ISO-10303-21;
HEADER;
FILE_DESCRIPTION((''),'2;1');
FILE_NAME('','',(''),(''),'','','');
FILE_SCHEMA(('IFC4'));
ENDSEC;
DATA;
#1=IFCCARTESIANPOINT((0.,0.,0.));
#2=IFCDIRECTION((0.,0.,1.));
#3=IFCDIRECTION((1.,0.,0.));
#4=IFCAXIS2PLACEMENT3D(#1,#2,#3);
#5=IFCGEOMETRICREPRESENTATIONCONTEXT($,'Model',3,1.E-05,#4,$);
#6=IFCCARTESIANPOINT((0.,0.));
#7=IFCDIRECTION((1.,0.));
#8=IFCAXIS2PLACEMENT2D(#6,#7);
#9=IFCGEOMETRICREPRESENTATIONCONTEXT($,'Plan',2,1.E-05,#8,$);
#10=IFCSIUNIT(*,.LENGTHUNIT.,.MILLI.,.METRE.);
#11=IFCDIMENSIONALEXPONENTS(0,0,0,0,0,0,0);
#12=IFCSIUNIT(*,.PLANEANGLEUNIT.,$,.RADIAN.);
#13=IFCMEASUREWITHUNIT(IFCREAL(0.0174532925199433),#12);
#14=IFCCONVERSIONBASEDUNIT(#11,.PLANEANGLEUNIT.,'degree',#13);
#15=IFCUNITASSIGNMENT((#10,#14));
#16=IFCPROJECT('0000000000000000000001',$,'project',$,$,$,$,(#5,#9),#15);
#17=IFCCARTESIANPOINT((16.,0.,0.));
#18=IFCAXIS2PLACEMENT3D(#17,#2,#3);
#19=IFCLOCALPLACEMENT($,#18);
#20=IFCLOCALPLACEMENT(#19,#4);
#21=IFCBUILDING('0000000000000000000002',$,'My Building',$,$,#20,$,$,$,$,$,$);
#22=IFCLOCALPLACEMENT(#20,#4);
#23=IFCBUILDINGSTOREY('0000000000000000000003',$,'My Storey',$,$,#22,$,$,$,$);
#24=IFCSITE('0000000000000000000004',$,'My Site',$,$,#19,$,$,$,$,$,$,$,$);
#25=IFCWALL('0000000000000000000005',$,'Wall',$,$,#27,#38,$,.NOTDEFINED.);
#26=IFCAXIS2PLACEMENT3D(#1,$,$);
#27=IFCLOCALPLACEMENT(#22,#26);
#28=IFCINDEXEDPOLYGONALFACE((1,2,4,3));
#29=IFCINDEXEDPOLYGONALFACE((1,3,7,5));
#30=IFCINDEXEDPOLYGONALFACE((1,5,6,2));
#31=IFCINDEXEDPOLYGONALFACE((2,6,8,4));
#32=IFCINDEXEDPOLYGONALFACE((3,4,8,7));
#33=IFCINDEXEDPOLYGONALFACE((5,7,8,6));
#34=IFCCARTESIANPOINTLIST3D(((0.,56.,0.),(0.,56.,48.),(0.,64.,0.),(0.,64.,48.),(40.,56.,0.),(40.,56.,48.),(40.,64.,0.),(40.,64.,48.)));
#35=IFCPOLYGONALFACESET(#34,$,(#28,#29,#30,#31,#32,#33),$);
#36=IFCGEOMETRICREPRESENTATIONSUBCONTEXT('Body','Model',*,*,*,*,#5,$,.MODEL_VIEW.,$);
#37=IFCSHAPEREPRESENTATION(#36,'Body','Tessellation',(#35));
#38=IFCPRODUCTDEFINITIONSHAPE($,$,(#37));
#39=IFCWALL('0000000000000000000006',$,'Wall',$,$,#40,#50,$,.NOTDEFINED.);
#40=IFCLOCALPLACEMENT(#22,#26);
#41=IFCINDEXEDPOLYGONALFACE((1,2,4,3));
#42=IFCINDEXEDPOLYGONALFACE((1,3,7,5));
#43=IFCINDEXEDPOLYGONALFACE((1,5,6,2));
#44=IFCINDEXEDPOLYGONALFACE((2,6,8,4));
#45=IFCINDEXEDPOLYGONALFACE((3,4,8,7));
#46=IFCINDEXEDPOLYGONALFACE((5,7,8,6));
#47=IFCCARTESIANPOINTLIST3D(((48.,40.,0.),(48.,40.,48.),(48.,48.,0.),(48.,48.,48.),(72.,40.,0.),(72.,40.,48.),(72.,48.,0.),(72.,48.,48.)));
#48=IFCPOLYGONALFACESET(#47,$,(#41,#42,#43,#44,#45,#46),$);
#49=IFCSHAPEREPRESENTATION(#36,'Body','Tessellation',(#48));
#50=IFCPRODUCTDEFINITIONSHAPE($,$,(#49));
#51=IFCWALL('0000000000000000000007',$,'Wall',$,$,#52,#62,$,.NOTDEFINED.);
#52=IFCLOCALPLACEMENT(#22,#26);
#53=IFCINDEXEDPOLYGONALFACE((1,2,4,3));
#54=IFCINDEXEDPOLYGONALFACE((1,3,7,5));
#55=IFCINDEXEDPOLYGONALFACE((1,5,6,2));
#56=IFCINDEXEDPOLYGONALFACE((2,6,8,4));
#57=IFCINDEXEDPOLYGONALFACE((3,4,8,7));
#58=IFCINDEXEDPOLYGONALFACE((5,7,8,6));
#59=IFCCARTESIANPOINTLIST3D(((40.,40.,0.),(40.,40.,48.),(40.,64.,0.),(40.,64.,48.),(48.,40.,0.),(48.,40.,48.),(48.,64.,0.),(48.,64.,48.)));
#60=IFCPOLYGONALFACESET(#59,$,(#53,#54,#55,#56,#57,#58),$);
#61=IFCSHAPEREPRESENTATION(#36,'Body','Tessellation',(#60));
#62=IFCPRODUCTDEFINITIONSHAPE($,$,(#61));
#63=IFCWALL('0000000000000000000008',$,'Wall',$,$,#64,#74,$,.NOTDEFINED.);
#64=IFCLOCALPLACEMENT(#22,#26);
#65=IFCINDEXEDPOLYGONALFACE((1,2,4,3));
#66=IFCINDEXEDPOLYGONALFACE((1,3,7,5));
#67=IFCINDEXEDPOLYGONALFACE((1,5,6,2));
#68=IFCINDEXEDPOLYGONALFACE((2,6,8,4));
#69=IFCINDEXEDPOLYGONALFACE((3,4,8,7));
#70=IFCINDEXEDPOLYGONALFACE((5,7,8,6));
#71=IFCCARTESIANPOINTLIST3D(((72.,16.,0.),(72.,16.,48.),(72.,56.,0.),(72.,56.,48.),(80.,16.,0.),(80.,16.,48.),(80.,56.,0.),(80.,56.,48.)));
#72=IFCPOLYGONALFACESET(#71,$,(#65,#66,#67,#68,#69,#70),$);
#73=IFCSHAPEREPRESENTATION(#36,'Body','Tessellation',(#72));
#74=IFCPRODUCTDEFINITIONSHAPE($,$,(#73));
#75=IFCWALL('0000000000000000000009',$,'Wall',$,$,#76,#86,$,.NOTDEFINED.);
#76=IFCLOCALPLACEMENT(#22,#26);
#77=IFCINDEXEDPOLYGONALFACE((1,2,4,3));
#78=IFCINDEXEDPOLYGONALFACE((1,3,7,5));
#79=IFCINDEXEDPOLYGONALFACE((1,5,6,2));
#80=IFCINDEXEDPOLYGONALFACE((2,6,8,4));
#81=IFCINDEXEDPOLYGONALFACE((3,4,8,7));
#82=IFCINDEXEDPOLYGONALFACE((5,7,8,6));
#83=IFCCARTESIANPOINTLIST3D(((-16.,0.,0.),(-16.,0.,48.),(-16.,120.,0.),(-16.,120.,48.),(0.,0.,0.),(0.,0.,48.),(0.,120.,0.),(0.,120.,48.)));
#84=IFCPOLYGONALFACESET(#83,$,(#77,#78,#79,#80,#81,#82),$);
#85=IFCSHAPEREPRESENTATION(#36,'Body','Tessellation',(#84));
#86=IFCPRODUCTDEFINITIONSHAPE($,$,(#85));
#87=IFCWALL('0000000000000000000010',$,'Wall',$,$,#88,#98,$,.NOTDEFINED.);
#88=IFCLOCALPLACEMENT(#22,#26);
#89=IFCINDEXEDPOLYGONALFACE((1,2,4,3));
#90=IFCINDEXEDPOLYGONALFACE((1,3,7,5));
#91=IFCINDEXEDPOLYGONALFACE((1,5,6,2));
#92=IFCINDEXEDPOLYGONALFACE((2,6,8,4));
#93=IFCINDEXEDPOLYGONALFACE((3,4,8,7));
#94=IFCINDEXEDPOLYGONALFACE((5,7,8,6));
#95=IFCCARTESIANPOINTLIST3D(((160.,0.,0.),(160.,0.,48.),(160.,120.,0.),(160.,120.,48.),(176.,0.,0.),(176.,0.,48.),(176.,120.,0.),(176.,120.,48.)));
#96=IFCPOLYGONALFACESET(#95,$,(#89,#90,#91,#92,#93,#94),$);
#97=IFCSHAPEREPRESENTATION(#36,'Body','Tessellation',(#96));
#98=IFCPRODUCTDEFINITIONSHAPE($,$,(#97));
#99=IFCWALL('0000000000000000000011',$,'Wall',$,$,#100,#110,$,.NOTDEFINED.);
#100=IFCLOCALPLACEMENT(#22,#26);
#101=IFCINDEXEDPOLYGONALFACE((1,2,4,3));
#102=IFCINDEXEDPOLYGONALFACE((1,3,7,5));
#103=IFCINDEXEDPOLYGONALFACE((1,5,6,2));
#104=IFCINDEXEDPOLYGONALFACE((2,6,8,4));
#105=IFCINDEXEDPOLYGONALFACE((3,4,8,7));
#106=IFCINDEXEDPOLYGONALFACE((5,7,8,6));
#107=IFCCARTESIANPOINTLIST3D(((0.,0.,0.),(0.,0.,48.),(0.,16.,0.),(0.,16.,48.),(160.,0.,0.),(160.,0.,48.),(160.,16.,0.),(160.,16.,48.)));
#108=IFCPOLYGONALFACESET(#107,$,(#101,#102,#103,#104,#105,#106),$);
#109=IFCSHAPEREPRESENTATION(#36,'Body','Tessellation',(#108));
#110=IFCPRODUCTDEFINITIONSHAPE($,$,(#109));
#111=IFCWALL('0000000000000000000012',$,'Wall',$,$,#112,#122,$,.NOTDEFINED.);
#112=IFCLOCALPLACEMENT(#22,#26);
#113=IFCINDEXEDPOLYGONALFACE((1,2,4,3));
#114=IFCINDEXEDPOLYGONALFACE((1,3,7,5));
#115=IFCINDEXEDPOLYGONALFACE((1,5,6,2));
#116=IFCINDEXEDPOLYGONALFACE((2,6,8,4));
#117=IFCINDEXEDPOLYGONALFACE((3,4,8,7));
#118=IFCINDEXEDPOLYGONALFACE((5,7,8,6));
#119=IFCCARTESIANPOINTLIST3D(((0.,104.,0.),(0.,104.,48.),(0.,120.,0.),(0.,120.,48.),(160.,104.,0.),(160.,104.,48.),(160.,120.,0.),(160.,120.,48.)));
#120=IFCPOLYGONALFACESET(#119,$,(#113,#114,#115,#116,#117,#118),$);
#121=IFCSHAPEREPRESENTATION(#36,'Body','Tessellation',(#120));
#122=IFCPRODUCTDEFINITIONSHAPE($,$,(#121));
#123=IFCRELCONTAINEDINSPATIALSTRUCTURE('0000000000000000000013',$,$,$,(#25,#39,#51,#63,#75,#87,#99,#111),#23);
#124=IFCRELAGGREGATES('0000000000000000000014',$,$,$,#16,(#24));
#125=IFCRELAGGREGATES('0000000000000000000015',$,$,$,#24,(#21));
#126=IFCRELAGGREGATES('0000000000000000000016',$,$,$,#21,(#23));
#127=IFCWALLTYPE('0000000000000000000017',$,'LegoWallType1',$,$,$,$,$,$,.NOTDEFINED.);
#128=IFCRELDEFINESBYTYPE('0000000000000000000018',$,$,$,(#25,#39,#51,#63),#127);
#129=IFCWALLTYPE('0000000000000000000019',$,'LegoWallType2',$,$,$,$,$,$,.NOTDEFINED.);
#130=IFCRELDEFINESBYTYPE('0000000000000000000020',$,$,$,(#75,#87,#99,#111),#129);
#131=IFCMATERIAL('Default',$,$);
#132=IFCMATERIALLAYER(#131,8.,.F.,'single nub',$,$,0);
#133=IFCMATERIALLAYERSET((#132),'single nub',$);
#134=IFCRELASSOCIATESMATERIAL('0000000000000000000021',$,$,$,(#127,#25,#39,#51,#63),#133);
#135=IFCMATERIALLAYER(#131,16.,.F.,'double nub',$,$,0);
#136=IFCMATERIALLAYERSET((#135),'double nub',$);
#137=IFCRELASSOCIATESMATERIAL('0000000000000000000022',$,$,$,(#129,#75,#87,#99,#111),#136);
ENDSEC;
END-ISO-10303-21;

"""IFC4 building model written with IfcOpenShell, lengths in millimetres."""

from ifc_helpers import new_model, entity, si_unit, converted_unit, frame, origin_with_axes, origin_2d_with_axis, place, context, subcontext, project, spatial, indexed_curve, outline, extrude, material, layer, layer_set, layer_usage, type_object, element, save


model = new_model("IFC4")

# Units and contexts
model_context = context("Model", 3, precision=1e-05, world=origin_with_axes())
plan_context = context("Plan", 2, precision=1e-05, world=origin_2d_with_axis())
body_context = subcontext(model_context, "Body", "Model", "MODEL_VIEW")
ifc_project = project(units=[si_unit("LENGTHUNIT", "METRE", prefix="MILLI"), converted_unit("PLANEANGLEUNIT", "degree", entity("IfcReal", 0.0174532925199433), si_unit("PLANEANGLEUNIT", "RADIAN"), dimensions=[0, 0, 0, 0, 0, 0, 0])], contexts=[model_context, plan_context])

# Site, building, storey
site_placement = place(None, frame((16.0, 0.0, 0.0), z_axis=(0.0, 0.0, 1.0), x_axis=(1.0, 0.0, 0.0)))
site = spatial("IfcSite", under=ifc_project, at=site_placement, Name="My Site")
building_placement = place(site_placement, origin_with_axes())
building = spatial("IfcBuilding", under=site, at=building_placement, Name="My Building")
storey_placement = place(building_placement, origin_with_axes())
storey = spatial("IfcBuildingStorey", under=building, at=storey_placement, Name="My Storey")

# Walls
ifc_material = material(Name="Default")
ifc_layer_1 = layer(ifc_material, 8.0, ventilated=False, Name="single nub", Priority=0)
ifc_layer_set_1 = layer_set([ifc_layer_1], Name="single nub")
ifc_layer_usage_1 = layer_usage(ifc_layer_set_1, "AXIS2", "POSITIVE", 0.0)
wall_type_1 = type_object("IfcWallType", Name="LegoWallType1", PredefinedType="NOTDEFINED", material=ifc_layer_set_1)
wall_1_placement = place(storey_placement, frame((0.0, 56.0, 0.0), z_axis=(0.0, 0.0, 1.0), x_axis=(1.0, 0.0, 0.0)))
element("IfcWall", 1, at=wall_1_placement, inside=storey, type_object=wall_type_1, material=ifc_layer_usage_1, Name="Wall", PredefinedType="NOTDEFINED", context=body_context, shape_type="SweptSolid", body=[
    extrude(outline(indexed_curve([(0.0, 0.0), (0.0, 8.0), (40.0, 8.0), (40.0, 0.0), (0.0, 0.0)], self_intersect=False)), origin_with_axes(), (0.0, 0.0, 1.0), 48.0),
])
ifc_layer_usage_2 = layer_usage(ifc_layer_set_1, "AXIS2", "POSITIVE", 0.0)
wall_2_placement = place(storey_placement, frame((48.0, 40.0, 0.0), z_axis=(0.0, 0.0, 1.0), x_axis=(1.0, 0.0, 0.0)))
element("IfcWall", 2, at=wall_2_placement, inside=storey, type_object=wall_type_1, material=ifc_layer_usage_2, Name="Wall", PredefinedType="NOTDEFINED", context=body_context, shape_type="SweptSolid", body=[
    extrude(outline(indexed_curve([(0.0, 0.0), (0.0, 8.0), (24.0, 8.0), (24.0, 0.0), (0.0, 0.0)], self_intersect=False)), origin_with_axes(), (0.0, 0.0, 1.0), 48.0),
])
ifc_layer_usage_3 = layer_usage(ifc_layer_set_1, "AXIS2", "POSITIVE", 0.0)
wall_3_placement = place(storey_placement, frame((48.0, 40.0, 0.0), z_axis=(0.0, 0.0, 1.0), x_axis=(0.000001, 1.0, 0.0)))
element("IfcWall", 3, at=wall_3_placement, inside=storey, type_object=wall_type_1, material=ifc_layer_usage_3, Name="Wall", PredefinedType="NOTDEFINED", context=body_context, shape_type="SweptSolid", body=[
    extrude(outline(indexed_curve([(0.0, 0.0), (0.0, 8.0), (24.0, 8.0), (24.0, 0.0), (0.0, 0.0)], self_intersect=False)), origin_with_axes(), (0.0, 0.0, 1.0), 48.0),
])
ifc_layer_usage_4 = layer_usage(ifc_layer_set_1, "AXIS2", "POSITIVE", 0.0)
wall_4_placement = place(storey_placement, frame((80.0, 16.0, 0.0), z_axis=(0.0, 0.0, 1.0), x_axis=(0.000001, 1.0, 0.0)))
element("IfcWall", 4, at=wall_4_placement, inside=storey, type_object=wall_type_1, material=ifc_layer_usage_4, Name="Wall", PredefinedType="NOTDEFINED", context=body_context, shape_type="SweptSolid", body=[
    extrude(outline(indexed_curve([(0.0, 0.0), (0.0, 8.0), (40.0, 8.0), (40.0, 0.0), (0.0, 0.0)], self_intersect=False)), origin_with_axes(), (0.0, 0.0, 1.0), 48.0),
])
ifc_layer_2 = layer(ifc_material, 16.0, ventilated=False, Name="double nub", Priority=0)
ifc_layer_set_2 = layer_set([ifc_layer_2], Name="double nub")
ifc_layer_usage_5 = layer_usage(ifc_layer_set_2, "AXIS2", "POSITIVE", 0.0)
wall_type_2 = type_object("IfcWallType", Name="LegoWallType2", PredefinedType="NOTDEFINED", material=ifc_layer_set_2)
wall_5_placement = place(storey_placement, frame((0.0, 0.0, 0.0), z_axis=(0.0, 0.0, 1.0), x_axis=(0.000001, 1.0, 0.0)))
element("IfcWall", 5, at=wall_5_placement, inside=storey, type_object=wall_type_2, material=ifc_layer_usage_5, Name="Wall", PredefinedType="NOTDEFINED", context=body_context, shape_type="SweptSolid", body=[
    extrude(outline(indexed_curve([(0.0, 0.0), (0.0, 16.0), (120.0, 16.0), (120.0, 0.0), (0.0, 0.0)], self_intersect=False)), origin_with_axes(), (0.0, 0.0, 1.0), 48.0),
])
ifc_layer_usage_6 = layer_usage(ifc_layer_set_2, "AXIS2", "POSITIVE", 0.0)
wall_6_placement = place(storey_placement, frame((176.0, 0.0, 0.0), z_axis=(0.0, 0.0, 1.0), x_axis=(0.000001, 1.0, 0.0)))
element("IfcWall", 6, at=wall_6_placement, inside=storey, type_object=wall_type_2, material=ifc_layer_usage_6, Name="Wall", PredefinedType="NOTDEFINED", context=body_context, shape_type="SweptSolid", body=[
    extrude(outline(indexed_curve([(0.0, 0.0), (0.0, 16.0), (120.0, 16.0), (120.0, 0.0), (0.0, 0.0)], self_intersect=False)), origin_with_axes(), (0.0, 0.0, 1.0), 48.0),
])
ifc_layer_usage_7 = layer_usage(ifc_layer_set_2, "AXIS2", "POSITIVE", 0.0)
wall_7_placement = place(storey_placement, origin_with_axes())
element("IfcWall", 7, at=wall_7_placement, inside=storey, type_object=wall_type_2, material=ifc_layer_usage_7, Name="Wall", PredefinedType="NOTDEFINED", context=body_context, shape_type="SweptSolid", body=[
    extrude(outline(indexed_curve([(0.0, 0.0), (0.0, 16.0), (160.0, 16.0), (160.0, 0.0), (0.0, 0.0)], self_intersect=False)), origin_with_axes(), (0.0, 0.0, 1.0), 48.0),
])
ifc_layer_usage_8 = layer_usage(ifc_layer_set_2, "AXIS2", "POSITIVE", 0.0)
wall_8_placement = place(storey_placement, frame((0.0, 104.0, 0.0), z_axis=(0.0, 0.0, 1.0), x_axis=(1.0, -0.000001, 0.0)))
element("IfcWall", 8, at=wall_8_placement, inside=storey, type_object=wall_type_2, material=ifc_layer_usage_8, Name="Wall", PredefinedType="NOTDEFINED", context=body_context, shape_type="SweptSolid", body=[
    extrude(outline(indexed_curve([(0.0, 0.0), (0.0, 16.0), (160.0, 16.0), (160.0, 0.0), (0.0, 0.0)], self_intersect=False)), origin_with_axes(), (0.0, 0.0, 1.0), 48.0),
])

save(model, "model.ifc")
